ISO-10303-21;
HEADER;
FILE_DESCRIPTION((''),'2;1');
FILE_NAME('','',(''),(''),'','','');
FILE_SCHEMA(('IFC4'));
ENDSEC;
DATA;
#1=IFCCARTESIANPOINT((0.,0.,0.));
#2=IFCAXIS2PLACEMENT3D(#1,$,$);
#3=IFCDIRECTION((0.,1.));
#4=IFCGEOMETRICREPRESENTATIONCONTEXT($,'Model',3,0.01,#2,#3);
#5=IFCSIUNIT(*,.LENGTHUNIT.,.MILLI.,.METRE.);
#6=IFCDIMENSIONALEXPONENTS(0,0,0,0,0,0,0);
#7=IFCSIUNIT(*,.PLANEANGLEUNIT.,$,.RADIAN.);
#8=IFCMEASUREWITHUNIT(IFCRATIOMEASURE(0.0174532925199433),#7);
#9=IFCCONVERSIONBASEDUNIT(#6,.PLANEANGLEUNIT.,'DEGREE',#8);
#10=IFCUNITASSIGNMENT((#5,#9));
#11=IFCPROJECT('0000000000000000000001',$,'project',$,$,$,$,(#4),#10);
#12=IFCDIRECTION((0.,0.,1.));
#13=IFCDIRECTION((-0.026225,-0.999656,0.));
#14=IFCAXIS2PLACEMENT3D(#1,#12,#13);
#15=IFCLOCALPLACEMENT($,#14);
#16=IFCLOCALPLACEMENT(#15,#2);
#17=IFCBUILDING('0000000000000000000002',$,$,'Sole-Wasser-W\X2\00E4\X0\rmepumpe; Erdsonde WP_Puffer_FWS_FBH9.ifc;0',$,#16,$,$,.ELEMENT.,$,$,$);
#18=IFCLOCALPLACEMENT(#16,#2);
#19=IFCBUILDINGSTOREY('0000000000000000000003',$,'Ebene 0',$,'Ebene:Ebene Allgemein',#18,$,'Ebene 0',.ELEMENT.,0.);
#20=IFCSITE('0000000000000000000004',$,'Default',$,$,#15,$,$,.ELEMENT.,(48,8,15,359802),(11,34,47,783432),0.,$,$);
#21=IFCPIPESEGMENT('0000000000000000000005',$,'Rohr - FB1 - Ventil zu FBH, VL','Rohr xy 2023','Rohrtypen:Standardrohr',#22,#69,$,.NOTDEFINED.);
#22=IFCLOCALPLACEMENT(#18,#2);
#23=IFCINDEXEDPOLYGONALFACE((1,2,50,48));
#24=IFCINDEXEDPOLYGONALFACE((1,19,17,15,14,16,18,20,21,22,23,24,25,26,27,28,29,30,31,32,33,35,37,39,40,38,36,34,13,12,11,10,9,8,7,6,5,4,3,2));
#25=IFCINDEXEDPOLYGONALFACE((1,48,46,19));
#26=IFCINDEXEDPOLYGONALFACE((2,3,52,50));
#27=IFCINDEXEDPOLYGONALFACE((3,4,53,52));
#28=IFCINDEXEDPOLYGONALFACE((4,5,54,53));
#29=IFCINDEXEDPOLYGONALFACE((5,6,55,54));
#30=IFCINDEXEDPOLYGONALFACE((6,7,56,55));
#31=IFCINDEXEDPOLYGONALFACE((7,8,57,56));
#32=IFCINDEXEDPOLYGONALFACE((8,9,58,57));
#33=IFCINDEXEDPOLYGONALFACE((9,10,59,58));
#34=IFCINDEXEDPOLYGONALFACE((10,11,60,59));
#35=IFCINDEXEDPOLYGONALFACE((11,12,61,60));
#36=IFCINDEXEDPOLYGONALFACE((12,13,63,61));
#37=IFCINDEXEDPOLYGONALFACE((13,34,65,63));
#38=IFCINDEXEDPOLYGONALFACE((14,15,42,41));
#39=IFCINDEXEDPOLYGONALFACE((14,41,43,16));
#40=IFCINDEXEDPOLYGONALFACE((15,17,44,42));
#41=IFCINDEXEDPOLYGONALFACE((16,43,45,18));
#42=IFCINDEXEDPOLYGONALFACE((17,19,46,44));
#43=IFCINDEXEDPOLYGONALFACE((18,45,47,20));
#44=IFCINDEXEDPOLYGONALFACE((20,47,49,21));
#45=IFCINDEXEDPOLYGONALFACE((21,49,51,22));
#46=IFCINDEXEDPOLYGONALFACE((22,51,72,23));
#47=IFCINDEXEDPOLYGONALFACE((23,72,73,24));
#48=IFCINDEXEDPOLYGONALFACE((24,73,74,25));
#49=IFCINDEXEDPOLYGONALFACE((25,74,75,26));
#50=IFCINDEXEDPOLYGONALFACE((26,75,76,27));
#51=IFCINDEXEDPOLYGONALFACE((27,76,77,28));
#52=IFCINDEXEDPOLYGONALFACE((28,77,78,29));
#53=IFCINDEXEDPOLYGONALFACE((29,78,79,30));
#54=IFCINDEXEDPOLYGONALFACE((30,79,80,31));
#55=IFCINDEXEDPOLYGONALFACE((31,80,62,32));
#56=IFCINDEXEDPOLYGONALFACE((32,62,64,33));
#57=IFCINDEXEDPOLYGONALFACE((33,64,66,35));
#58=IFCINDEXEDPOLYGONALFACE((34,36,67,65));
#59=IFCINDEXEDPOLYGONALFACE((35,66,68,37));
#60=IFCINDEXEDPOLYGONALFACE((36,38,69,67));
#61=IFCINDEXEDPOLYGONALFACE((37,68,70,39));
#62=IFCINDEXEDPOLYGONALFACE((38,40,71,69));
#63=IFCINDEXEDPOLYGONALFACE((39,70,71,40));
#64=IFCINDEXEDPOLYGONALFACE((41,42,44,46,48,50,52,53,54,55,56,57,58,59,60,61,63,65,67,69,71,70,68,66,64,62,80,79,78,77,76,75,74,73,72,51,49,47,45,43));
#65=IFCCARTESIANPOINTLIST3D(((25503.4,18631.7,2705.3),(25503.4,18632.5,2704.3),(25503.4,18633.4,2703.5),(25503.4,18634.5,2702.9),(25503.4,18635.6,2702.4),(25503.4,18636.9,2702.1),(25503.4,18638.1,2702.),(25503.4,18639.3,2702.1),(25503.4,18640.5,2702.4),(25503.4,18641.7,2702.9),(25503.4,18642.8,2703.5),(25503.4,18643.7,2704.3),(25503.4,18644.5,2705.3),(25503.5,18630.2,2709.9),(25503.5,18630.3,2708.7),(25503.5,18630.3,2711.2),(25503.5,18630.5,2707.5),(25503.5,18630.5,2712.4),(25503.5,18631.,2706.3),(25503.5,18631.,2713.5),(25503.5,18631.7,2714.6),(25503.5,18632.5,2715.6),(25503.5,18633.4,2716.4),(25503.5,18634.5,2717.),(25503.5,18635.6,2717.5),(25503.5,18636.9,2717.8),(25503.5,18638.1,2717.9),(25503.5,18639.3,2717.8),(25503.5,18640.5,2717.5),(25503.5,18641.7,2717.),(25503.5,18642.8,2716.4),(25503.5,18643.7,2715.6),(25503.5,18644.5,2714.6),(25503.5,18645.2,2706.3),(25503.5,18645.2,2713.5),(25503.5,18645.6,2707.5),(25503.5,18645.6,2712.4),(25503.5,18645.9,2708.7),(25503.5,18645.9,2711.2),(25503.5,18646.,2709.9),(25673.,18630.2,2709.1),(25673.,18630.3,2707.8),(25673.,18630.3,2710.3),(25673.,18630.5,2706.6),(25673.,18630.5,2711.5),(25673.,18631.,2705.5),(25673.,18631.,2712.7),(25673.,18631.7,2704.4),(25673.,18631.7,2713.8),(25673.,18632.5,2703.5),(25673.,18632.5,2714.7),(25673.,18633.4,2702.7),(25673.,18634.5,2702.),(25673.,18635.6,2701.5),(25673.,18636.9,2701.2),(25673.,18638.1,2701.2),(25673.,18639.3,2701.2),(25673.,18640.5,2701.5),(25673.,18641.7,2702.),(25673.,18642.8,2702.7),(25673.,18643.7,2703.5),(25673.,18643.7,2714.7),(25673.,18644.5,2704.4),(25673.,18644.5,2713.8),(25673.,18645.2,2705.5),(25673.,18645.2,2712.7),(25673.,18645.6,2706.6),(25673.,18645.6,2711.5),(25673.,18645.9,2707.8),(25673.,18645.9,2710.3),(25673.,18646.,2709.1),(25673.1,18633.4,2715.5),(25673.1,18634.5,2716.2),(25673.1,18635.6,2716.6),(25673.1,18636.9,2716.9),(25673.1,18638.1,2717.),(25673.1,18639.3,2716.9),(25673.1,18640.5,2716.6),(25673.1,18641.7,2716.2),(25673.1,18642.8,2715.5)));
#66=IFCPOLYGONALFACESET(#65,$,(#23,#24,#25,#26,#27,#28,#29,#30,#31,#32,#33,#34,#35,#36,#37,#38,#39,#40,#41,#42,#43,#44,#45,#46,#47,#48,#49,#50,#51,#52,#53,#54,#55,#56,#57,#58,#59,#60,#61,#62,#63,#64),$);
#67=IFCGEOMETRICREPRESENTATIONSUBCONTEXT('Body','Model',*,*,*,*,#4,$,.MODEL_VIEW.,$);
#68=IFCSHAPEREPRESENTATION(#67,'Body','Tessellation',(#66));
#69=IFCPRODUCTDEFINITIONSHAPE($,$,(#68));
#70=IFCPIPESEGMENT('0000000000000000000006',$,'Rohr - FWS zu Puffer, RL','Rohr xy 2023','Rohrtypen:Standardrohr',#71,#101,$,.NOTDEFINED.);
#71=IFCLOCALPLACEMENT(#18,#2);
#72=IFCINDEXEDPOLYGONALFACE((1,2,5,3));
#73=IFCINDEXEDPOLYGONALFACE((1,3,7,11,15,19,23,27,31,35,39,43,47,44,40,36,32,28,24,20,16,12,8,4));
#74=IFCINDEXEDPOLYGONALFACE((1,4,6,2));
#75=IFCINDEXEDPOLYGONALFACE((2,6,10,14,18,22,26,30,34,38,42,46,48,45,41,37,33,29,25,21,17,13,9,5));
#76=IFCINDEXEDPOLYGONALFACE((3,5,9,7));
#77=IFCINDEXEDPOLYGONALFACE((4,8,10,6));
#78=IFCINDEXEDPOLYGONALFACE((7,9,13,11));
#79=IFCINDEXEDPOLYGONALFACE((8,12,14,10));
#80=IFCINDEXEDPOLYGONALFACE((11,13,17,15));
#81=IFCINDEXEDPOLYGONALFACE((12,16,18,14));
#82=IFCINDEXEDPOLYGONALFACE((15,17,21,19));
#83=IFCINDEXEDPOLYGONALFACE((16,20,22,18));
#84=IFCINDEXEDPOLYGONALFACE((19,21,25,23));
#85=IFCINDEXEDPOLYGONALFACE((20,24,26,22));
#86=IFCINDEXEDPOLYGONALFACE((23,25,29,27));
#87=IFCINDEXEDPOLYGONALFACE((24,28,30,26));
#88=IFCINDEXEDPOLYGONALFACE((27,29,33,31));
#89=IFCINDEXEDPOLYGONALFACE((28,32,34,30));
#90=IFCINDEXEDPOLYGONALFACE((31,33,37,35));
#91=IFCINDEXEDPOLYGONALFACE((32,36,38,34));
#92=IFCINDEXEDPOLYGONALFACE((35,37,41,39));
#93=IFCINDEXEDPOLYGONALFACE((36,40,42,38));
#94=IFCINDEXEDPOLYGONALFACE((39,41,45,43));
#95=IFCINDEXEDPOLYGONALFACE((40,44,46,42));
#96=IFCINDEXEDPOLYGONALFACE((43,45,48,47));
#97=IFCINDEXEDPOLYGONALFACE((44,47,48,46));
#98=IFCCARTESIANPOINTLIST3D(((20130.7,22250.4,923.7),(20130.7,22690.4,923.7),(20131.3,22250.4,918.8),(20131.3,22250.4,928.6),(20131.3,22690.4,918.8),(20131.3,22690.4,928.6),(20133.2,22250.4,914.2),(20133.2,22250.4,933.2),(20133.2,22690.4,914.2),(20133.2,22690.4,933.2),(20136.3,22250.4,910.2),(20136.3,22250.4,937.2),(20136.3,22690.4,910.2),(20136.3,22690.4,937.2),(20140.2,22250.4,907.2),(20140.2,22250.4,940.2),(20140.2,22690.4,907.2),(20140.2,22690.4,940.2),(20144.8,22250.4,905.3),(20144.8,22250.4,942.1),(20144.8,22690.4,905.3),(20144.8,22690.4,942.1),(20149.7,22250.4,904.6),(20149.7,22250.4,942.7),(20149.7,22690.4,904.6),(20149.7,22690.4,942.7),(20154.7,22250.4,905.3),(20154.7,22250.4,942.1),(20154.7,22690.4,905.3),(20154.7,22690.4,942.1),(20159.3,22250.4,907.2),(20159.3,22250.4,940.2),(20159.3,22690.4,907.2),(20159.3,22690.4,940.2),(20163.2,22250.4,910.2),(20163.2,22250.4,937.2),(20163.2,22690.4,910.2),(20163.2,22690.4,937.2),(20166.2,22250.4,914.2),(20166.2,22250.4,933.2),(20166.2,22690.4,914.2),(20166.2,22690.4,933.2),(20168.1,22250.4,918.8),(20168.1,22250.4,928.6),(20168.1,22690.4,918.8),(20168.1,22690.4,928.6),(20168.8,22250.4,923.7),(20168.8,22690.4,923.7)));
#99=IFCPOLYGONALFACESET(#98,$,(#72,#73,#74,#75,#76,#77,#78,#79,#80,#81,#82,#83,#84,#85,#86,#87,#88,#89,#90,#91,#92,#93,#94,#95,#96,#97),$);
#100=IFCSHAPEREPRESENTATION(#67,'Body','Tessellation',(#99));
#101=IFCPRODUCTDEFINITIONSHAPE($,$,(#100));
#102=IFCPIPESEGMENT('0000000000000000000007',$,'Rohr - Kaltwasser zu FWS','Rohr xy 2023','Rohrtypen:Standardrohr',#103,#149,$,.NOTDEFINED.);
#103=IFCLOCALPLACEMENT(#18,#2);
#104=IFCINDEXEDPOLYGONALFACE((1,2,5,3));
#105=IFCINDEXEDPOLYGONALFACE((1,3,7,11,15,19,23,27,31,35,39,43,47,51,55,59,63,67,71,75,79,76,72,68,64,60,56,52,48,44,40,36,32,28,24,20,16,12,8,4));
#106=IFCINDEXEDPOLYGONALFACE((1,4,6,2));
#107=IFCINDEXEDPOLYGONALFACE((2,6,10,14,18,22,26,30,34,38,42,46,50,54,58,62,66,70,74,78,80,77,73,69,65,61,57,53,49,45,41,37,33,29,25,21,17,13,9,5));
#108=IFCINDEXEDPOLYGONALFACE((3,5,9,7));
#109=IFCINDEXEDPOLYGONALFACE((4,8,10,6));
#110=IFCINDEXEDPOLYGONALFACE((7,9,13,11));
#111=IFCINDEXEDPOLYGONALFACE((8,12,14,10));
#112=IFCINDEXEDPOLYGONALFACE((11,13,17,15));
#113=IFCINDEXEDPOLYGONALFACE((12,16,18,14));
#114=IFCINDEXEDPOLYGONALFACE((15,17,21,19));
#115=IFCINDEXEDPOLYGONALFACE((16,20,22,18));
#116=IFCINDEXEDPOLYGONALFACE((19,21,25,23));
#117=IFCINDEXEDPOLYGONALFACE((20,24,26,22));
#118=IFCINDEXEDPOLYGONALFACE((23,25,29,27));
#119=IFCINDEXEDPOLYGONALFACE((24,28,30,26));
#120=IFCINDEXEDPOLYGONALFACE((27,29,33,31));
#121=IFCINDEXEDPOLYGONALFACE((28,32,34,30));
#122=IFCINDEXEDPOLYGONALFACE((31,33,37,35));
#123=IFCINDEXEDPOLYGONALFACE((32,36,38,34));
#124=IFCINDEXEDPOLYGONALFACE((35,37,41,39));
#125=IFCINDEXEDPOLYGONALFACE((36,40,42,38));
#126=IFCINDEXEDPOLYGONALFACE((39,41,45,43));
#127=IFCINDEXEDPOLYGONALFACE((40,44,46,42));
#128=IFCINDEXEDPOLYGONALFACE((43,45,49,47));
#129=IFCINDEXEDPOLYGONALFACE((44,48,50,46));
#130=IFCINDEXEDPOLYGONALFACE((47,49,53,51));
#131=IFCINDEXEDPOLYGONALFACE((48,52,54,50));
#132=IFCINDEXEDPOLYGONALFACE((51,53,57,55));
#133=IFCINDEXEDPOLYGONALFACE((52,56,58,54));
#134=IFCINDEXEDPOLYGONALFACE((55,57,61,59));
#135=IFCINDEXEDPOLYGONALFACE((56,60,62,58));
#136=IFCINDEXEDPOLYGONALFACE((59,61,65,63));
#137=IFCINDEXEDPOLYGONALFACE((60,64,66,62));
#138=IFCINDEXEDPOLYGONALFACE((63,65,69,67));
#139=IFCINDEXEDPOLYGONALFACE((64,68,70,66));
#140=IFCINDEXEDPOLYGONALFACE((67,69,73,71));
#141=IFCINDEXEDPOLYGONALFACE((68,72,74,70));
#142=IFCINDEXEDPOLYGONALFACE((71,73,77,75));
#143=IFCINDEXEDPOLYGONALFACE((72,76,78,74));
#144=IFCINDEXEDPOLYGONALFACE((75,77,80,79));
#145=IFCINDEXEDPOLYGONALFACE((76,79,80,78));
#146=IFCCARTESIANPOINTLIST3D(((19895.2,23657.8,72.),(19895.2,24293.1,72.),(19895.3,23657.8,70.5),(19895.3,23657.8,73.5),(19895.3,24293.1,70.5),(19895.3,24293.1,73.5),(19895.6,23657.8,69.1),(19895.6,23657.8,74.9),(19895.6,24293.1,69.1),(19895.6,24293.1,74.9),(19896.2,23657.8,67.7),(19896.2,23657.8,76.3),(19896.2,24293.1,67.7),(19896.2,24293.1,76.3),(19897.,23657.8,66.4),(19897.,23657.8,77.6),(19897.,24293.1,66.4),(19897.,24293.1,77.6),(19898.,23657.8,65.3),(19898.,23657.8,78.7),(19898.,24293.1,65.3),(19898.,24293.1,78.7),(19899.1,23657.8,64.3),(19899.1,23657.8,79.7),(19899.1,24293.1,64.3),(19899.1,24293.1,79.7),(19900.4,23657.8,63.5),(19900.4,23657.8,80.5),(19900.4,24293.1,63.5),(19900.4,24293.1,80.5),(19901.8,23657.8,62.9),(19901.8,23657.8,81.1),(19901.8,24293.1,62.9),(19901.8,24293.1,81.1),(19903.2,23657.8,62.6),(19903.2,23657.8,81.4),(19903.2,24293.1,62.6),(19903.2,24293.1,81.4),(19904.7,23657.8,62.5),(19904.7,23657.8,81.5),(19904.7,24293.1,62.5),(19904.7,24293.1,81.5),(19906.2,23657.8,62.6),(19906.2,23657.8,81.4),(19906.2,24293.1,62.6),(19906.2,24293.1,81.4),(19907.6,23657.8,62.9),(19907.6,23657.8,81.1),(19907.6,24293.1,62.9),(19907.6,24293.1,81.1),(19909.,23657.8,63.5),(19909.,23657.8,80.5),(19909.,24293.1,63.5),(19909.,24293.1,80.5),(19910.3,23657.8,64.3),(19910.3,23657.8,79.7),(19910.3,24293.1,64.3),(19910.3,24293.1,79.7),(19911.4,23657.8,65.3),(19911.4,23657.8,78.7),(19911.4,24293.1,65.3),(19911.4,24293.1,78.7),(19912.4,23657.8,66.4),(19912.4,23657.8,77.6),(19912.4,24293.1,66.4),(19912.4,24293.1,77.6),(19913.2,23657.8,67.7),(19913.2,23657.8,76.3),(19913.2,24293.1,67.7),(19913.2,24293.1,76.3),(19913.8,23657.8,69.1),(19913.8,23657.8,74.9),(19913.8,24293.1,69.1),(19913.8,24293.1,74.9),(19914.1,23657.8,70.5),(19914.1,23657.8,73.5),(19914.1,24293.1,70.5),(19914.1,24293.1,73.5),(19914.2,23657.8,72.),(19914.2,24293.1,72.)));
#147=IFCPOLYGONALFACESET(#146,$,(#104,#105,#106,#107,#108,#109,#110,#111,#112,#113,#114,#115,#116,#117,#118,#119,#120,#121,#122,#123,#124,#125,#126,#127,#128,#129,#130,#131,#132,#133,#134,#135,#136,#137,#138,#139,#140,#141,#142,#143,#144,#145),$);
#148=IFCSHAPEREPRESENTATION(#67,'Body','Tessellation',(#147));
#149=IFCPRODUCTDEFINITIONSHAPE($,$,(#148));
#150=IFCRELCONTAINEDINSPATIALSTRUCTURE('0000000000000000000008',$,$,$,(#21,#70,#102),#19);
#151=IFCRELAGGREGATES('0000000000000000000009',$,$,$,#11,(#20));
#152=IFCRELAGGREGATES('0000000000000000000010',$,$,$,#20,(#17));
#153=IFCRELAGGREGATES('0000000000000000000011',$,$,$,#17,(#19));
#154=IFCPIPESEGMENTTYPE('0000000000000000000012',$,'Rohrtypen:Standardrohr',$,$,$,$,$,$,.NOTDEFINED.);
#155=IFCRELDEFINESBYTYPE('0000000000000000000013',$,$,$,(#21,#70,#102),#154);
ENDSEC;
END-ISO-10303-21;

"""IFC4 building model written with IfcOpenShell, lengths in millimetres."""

from ifc_helpers import new_model, entity, si_unit, converted_unit, direction, frame, origin, place, context, subcontext, project, spatial, indexed_curve, outline, extrude, type_object, element, save


model = new_model("IFC4")

# Units and contexts
model_context = context("Model", 3, precision=0.01, world=origin(), true_north=direction((0.0, 1.0)))
body_context = subcontext(model_context, "Body", "Model", "MODEL_VIEW")
ifc_project = project(units=[si_unit("LENGTHUNIT", "METRE", prefix="MILLI"), converted_unit("PLANEANGLEUNIT", "DEGREE", entity("IfcRatioMeasure", 0.0174532925199433), si_unit("PLANEANGLEUNIT", "RADIAN"), dimensions=[0, 0, 0, 0, 0, 0, 0])], contexts=[model_context])

# Site, building, storey
site_placement = place(None, frame((0.0, 0.0, 0.0), z_axis=(0.0, 0.0, 1.0), x_axis=(-0.026225, -0.999656, 0.0)))
site = spatial("IfcSite", under=ifc_project, at=site_placement, Name="Default", CompositionType="ELEMENT", RefLatitude=(48, 8, 15, 359802), RefLongitude=(11, 34, 47, 783432), RefElevation=0.0)
building_placement = place(site_placement, origin())
building = spatial("IfcBuilding", under=site, at=building_placement, Description="Sole-Wasser-Wärmepumpe; Erdsonde WP_Puffer_FWS_FBH9.ifc;0", CompositionType="ELEMENT")
storey_placement = place(building_placement, origin())
storey = spatial("IfcBuildingStorey", under=building, at=storey_placement, Name="Ebene 0", ObjectType="Ebene:Ebene Allgemein", LongName="Ebene 0", CompositionType="ELEMENT", Elevation=0.0)

# Pipe segments
pipe_segment_type = type_object("IfcPipeSegmentType", Name="Rohrtypen:Standardrohr", PredefinedType="NOTDEFINED")
pipe_segment_1_placement = place(storey_placement, origin())
element("IfcPipeSegment", 1, at=pipe_segment_1_placement, inside=storey, type_object=pipe_segment_type, Name="Rohr - FB1 - Ventil zu FBH, VL", Description="Rohr xy 2023", ObjectType="Rohrtypen:Standardrohr", PredefinedType="NOTDEFINED", context=body_context, shape_type="SweptSolid", body=[
    extrude(outline(indexed_curve([(7.9, 0.0), (7.8, 1.2), (7.6, 2.5), (7.1, 3.6), (6.4, 4.7), (5.6, 5.6), (4.7, 6.4), (3.6, 7.1), (2.5, 7.6), (1.2, 7.8), (0.0, 7.9), (-1.2, 7.8), (-2.5, 7.6), (-3.6, 7.1), (-4.7, 6.4), (-5.6, 5.6), (-6.4, 4.7), (-7.1, 3.6), (-7.6, 2.5), (-7.8, 1.2), (-7.9, 0.0), (-7.8, -1.2), (-7.6, -2.5), (-7.1, -3.6), (-6.4, -4.7), (-5.6, -5.6), (-4.7, -6.4), (-3.6, -7.1), (-2.5, -7.6), (-1.2, -7.8), (0.0, -7.9), (1.2, -7.8), (2.5, -7.6), (3.6, -7.1), (4.7, -6.4), (5.6, -5.6), (6.4, -4.7), (7.1, -3.6), (7.6, -2.5), (7.8, -1.2), (7.9, 0.0)], self_intersect=False)), frame((25503.5, 18638.1, 2709.9), z_axis=(0.999988, 0.0, -0.005), x_axis=(0.0, 1.0, 0.0)), (0.0, 0.0, 1.0), 169.5),
])
pipe_segment_2_placement = place(storey_placement, origin())
element("IfcPipeSegment", 2, at=pipe_segment_2_placement, inside=storey, type_object=pipe_segment_type, Name="Rohr - FWS zu Puffer, RL", Description="Rohr xy 2023", ObjectType="Rohrtypen:Standardrohr", PredefinedType="NOTDEFINED", context=body_context, shape_type="SweptSolid", body=[
    extrude(outline(indexed_curve([(-2.5, -18.9), (2.5, -18.9), (7.3, -17.6), (11.6, -15.1), (15.1, -11.6), (17.6, -7.3), (18.9, -2.5), (18.9, 2.5), (17.6, 7.3), (15.1, 11.6), (11.6, 15.1), (7.3, 17.6), (2.5, 18.9), (-2.5, 18.9), (-7.3, 17.6), (-11.6, 15.1), (-15.1, 11.6), (-17.6, 7.3), (-18.9, 2.5), (-18.9, -2.5), (-17.6, -7.3), (-15.1, -11.6), (-11.6, -15.1), (-7.3, -17.6), (-2.5, -18.9)], self_intersect=False)), frame((20149.7, 22250.4, 923.7), z_axis=(0.0, 1.0, 0.0), x_axis=(0.130526, 0.0, 0.991445)), (0.0, 0.0, 1.0), 440.0),
])
pipe_segment_3_placement = place(storey_placement, origin())
element("IfcPipeSegment", 3, at=pipe_segment_3_placement, inside=storey, type_object=pipe_segment_type, Name="Rohr - Kaltwasser zu FWS", Description="Rohr xy 2023", ObjectType="Rohrtypen:Standardrohr", PredefinedType="NOTDEFINED", context=body_context, shape_type="SweptSolid", body=[
    extrude(outline(indexed_curve([(9.5, 0.0), (9.4, 1.5), (9.1, 2.9), (8.5, 4.3), (7.7, 5.6), (6.7, 6.7), (5.6, 7.7), (4.3, 8.5), (2.9, 9.1), (1.5, 9.4), (0.0, 9.5), (-1.5, 9.4), (-2.9, 9.1), (-4.3, 8.5), (-5.6, 7.7), (-6.7, 6.7), (-7.7, 5.6), (-8.5, 4.3), (-9.1, 2.9), (-9.4, 1.5), (-9.5, 0.0), (-9.4, -1.5), (-9.1, -2.9), (-8.5, -4.3), (-7.7, -5.6), (-6.7, -6.7), (-5.6, -7.7), (-4.3, -8.5), (-2.9, -9.1), (-1.5, -9.4), (0.0, -9.5), (1.5, -9.4), (2.9, -9.1), (4.3, -8.5), (5.6, -7.7), (6.7, -6.7), (7.7, -5.6), (8.5, -4.3), (9.1, -2.9), (9.4, -1.5), (9.5, 0.0)], self_intersect=False)), frame((19904.7, 23657.8, 72.0), z_axis=(0.0, 1.0, 0.0), x_axis=(1.0, 0.0, 0.0)), (0.0, 0.0, 1.0), 635.3),
])

save(model, "model.ifc")
